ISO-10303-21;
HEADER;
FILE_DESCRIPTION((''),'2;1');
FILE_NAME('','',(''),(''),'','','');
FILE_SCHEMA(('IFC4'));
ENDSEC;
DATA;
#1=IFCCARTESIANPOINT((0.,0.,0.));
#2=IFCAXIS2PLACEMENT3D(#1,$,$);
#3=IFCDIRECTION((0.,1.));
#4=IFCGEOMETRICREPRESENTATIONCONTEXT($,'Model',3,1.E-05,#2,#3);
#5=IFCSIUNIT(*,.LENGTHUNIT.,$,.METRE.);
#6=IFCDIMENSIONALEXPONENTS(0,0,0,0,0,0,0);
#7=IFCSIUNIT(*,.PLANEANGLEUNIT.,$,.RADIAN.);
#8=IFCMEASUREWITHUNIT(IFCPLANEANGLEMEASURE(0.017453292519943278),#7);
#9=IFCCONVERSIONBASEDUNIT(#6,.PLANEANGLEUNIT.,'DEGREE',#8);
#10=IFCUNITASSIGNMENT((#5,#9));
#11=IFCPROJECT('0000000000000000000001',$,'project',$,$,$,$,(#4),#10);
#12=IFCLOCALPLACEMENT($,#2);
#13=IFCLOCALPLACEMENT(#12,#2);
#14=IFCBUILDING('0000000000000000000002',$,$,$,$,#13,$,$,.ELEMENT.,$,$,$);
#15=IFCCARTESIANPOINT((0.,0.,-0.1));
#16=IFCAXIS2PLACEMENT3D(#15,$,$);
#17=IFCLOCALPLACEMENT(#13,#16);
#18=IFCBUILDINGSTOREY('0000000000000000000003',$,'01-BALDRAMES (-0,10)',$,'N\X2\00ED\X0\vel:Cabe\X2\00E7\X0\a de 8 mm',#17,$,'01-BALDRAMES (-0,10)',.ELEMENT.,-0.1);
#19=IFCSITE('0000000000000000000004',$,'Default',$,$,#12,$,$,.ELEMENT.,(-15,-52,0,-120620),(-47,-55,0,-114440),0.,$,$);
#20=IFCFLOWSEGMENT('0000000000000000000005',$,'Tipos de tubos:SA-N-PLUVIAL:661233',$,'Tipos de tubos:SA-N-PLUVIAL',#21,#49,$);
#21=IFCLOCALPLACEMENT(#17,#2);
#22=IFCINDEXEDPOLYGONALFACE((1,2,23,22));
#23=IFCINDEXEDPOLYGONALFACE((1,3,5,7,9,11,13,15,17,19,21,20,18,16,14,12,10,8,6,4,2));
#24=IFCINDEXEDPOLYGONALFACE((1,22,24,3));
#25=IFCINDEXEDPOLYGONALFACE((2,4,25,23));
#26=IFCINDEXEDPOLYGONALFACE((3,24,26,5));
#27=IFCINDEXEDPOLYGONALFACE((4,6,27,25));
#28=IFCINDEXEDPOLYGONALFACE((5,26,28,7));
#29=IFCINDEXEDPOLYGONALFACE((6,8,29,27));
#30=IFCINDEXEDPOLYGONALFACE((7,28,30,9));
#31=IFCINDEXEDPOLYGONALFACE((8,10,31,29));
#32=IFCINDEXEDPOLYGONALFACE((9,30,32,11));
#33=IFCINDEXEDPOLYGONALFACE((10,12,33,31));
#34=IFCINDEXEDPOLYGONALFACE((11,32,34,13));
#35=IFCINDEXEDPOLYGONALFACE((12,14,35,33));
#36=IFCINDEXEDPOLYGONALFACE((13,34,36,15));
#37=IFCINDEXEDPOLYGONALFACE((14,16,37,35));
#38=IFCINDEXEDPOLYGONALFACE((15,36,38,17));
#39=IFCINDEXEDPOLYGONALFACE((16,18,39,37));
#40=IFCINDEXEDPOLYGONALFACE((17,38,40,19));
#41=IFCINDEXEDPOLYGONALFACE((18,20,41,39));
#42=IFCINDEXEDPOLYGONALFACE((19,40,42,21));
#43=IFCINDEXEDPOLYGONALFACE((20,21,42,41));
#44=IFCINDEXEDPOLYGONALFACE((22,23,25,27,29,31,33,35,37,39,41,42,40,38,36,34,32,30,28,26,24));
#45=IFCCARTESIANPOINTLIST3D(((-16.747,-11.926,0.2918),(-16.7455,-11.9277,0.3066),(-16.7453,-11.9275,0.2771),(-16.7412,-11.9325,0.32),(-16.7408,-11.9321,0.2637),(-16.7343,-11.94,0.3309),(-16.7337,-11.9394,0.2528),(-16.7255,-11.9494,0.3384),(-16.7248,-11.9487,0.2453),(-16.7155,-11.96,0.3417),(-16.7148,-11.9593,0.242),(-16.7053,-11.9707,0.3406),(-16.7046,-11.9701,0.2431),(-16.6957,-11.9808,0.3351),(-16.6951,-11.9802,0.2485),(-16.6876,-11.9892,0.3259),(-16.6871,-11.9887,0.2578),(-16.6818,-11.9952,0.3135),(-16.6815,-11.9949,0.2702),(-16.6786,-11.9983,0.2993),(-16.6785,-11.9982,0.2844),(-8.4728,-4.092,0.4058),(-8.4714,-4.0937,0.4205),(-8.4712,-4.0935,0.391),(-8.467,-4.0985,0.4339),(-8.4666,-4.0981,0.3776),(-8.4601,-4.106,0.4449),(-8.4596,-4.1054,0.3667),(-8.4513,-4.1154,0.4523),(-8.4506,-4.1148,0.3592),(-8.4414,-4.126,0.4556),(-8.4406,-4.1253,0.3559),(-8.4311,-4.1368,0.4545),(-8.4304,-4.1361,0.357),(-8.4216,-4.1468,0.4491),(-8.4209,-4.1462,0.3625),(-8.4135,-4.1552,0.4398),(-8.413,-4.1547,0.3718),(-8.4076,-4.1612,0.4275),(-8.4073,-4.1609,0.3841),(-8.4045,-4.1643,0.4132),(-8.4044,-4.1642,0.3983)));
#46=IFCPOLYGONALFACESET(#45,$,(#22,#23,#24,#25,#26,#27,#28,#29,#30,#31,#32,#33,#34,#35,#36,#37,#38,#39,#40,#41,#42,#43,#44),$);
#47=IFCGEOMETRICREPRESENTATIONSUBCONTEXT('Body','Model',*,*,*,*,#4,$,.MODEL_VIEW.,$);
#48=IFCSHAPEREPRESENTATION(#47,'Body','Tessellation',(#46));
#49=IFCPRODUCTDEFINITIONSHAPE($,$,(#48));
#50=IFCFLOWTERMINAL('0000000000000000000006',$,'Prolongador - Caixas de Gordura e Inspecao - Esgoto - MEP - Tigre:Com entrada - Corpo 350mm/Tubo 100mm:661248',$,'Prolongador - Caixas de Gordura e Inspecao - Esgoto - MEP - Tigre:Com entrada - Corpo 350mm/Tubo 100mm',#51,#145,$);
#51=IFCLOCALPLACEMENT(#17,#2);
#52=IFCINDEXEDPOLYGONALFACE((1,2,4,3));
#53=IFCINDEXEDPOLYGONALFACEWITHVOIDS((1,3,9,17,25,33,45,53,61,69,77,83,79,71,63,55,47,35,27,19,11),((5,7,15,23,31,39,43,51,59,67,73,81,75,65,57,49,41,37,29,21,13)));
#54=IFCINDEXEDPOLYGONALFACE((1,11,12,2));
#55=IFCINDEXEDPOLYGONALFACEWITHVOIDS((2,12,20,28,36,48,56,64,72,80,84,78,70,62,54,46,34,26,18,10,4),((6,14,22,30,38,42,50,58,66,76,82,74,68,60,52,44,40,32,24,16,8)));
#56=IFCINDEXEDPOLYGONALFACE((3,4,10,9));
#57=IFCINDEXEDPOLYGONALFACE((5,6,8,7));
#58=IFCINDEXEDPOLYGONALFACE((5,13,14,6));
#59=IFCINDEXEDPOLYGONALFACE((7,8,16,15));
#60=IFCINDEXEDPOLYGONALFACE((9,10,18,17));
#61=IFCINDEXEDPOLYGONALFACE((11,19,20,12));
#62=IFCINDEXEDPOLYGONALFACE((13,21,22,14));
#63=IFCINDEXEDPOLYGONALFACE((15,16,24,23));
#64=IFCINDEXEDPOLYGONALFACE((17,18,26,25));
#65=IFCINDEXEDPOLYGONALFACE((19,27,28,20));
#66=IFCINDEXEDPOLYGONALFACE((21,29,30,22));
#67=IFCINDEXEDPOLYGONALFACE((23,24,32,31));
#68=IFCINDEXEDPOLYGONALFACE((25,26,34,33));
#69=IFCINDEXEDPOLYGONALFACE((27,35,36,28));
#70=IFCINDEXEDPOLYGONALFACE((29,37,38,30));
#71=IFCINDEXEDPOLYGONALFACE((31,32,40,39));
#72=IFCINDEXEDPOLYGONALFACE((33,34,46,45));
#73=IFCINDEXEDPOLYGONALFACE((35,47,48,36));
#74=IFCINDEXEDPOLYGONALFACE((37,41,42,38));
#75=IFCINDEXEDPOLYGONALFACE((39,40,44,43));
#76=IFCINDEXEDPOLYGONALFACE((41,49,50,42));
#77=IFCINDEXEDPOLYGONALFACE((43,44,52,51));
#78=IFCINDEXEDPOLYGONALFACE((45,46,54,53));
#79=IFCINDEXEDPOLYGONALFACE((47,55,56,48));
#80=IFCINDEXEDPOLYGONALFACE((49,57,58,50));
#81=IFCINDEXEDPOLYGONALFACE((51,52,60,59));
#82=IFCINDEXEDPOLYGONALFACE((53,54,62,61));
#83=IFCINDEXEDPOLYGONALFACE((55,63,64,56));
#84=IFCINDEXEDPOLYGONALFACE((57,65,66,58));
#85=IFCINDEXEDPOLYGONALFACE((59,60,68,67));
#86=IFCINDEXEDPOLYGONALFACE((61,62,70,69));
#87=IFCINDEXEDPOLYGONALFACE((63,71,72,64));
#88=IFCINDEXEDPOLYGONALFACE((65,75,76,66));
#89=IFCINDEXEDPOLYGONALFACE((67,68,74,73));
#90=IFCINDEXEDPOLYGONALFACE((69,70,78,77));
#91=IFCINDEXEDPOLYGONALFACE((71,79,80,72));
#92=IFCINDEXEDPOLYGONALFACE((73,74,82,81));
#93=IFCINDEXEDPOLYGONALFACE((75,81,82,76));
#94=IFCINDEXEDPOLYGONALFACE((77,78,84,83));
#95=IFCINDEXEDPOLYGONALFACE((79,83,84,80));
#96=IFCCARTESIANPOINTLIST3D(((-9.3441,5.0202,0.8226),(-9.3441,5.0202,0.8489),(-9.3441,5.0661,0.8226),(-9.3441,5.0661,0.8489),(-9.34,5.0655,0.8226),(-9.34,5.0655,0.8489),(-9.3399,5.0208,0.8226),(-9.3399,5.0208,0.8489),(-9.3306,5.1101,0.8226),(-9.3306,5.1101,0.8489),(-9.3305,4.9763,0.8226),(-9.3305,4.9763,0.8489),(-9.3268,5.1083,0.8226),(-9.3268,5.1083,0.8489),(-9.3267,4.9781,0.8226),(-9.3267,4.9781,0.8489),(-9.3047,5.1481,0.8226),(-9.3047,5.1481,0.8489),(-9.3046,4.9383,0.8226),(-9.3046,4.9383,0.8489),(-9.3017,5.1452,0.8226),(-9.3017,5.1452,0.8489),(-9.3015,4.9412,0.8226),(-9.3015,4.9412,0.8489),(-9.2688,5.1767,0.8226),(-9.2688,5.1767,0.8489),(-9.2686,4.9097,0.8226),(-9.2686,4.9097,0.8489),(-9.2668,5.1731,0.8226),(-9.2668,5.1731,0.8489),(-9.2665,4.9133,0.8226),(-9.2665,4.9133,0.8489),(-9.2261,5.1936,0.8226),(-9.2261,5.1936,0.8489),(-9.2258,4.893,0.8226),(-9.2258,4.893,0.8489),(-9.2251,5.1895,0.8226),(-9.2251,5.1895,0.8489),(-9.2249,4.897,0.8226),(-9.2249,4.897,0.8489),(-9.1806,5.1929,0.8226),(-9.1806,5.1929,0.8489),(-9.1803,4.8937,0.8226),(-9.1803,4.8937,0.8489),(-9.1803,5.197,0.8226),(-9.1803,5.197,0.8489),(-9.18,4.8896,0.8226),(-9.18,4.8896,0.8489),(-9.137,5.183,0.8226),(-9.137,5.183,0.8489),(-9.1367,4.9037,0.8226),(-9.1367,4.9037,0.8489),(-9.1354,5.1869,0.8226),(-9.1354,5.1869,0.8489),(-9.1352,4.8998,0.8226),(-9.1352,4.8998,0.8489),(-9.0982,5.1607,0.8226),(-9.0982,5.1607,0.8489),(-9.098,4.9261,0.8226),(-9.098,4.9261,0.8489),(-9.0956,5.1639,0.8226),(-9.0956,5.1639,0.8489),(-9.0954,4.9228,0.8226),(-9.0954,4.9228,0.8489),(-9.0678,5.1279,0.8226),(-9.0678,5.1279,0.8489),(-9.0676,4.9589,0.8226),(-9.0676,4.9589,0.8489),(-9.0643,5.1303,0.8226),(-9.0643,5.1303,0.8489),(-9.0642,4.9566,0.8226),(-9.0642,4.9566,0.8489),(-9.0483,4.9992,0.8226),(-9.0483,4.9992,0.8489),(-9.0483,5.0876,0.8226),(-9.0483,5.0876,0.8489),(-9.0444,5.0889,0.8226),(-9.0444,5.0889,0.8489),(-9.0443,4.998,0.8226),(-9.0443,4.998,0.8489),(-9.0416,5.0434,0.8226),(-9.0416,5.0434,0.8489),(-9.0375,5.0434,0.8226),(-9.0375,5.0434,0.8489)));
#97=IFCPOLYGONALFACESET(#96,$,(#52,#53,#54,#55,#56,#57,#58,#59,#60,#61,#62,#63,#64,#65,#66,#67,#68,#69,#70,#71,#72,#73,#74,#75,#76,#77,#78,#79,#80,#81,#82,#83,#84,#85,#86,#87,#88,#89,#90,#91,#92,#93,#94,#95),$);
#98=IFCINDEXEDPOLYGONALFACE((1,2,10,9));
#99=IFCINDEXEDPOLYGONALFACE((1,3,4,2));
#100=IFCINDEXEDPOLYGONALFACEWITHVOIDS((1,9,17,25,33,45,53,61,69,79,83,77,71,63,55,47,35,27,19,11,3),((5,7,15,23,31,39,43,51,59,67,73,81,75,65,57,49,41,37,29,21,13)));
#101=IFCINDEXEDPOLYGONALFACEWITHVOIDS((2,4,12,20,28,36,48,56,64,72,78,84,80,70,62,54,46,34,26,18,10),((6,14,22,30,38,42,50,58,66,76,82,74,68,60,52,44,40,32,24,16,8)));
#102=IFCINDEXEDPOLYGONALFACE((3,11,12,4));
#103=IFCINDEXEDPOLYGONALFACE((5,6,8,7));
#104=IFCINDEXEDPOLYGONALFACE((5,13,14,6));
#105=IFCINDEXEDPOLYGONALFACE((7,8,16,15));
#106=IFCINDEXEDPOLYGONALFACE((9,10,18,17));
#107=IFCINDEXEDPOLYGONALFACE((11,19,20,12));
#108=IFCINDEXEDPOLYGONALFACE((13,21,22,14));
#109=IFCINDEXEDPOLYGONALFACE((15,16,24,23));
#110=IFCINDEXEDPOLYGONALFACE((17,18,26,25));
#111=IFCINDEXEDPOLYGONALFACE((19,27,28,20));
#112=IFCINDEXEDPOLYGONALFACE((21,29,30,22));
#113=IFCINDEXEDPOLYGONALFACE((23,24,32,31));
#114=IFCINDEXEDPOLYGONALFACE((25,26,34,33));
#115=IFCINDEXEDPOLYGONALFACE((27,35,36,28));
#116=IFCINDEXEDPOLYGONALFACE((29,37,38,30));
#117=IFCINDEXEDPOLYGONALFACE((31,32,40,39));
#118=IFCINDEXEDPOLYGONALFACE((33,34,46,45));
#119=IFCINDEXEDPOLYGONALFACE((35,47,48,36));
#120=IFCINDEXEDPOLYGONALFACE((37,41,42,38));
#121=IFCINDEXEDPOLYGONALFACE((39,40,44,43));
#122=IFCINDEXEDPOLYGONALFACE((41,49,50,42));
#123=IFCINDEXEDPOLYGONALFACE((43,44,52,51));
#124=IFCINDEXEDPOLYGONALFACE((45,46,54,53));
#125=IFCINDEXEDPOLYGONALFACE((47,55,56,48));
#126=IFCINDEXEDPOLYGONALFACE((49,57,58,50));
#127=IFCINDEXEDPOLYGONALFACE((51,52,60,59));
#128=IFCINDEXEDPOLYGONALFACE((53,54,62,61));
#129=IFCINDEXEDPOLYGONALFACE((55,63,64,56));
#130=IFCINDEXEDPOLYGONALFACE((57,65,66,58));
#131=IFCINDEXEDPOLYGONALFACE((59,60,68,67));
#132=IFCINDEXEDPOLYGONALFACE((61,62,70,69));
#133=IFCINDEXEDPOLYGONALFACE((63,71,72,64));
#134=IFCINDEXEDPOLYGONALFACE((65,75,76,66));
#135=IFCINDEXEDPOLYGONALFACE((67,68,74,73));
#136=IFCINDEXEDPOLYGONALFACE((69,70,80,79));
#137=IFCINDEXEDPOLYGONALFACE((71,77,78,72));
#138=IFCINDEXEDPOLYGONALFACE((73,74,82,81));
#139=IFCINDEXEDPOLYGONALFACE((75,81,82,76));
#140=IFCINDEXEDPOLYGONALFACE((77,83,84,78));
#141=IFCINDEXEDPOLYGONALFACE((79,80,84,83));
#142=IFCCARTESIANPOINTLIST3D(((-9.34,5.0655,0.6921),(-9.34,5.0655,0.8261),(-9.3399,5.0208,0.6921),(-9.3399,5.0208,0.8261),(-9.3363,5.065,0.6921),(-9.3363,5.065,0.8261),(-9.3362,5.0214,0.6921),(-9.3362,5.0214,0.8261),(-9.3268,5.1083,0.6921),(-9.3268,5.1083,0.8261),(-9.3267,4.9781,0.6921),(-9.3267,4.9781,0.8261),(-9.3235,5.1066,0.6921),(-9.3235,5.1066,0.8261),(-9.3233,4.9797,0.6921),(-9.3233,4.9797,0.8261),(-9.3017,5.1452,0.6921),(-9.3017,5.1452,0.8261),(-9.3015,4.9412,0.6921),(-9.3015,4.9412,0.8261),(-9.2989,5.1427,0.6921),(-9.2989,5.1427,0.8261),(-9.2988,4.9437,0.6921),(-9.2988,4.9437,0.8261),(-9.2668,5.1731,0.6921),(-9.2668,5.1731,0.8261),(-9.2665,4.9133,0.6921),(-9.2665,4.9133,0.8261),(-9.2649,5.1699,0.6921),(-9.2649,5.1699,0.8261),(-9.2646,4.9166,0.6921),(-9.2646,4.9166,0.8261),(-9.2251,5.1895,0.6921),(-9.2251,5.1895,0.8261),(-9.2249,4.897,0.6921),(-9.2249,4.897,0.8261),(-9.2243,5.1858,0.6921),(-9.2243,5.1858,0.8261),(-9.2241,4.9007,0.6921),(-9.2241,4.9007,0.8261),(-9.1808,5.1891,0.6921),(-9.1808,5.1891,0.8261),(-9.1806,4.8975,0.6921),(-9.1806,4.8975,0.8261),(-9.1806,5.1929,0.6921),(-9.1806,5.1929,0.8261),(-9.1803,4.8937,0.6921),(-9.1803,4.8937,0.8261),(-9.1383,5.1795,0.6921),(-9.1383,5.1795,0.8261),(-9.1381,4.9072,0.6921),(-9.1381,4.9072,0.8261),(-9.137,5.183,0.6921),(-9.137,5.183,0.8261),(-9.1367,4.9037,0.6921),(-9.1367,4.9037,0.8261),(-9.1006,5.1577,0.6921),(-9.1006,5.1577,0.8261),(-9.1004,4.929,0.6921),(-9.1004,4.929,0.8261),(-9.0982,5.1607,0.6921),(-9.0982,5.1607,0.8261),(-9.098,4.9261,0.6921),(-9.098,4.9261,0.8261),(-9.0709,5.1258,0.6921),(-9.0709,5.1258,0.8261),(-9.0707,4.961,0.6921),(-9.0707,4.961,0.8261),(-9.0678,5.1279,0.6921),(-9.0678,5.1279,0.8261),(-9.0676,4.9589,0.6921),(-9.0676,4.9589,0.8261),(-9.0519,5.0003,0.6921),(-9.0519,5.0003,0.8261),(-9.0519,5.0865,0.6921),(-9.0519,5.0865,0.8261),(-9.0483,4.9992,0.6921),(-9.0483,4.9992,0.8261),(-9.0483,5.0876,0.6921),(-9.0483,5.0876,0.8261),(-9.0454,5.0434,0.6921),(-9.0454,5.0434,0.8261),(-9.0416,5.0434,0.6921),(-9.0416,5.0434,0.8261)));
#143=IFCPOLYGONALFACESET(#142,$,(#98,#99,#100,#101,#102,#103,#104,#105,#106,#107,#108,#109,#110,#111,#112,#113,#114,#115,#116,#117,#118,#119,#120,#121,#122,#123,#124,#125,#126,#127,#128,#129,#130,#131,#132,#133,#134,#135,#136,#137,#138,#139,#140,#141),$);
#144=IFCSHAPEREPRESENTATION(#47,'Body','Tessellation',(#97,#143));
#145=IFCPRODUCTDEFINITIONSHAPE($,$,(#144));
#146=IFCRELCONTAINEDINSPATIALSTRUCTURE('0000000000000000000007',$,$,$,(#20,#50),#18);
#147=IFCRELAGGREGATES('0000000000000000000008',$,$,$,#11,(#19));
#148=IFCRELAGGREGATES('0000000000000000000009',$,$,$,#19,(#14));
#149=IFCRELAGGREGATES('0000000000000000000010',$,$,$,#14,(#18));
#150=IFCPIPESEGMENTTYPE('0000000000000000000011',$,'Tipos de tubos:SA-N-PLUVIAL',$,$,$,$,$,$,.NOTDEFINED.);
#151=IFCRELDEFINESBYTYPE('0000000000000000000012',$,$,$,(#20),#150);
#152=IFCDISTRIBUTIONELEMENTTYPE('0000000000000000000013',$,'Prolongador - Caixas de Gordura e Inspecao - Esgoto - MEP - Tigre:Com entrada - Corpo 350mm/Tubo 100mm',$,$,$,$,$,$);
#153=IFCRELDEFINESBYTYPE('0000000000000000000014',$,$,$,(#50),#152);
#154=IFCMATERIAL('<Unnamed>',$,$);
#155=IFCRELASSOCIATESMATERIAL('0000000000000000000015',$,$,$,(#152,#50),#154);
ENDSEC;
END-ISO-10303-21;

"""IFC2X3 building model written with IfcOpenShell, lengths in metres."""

from ifc_helpers import new_model, entity, si_unit, converted_unit, direction, frame, frame_2d, origin, place, context, subcontext, project, spatial, circle, hollow_circle, extrude, source, transform, mapped, material, type_object, type_shapes, element, save


model = new_model("IFC2X3")

# Units and contexts
model_context = context("Model", 3, precision=1e-05, world=origin(), true_north=direction((0.0, 1.0)))
body_context = subcontext(model_context, "Body", "Model", "MODEL_VIEW")
ifc_project = project(units=[si_unit("LENGTHUNIT", "METRE"), converted_unit("PLANEANGLEUNIT", "DEGREE", entity("IfcPlaneAngleMeasure", 0.017453292519943278), si_unit("PLANEANGLEUNIT", "RADIAN"), dimensions=[0, 0, 0, 0, 0, 0, 0])], contexts=[model_context])

# Site, building, storey
site_placement = place(None, origin())
site = spatial("IfcSite", under=ifc_project, at=site_placement, Name="Default", CompositionType="ELEMENT", RefLatitude=(-15, -52, 0, -120620), RefLongitude=(-47, -55, 0, -114440), RefElevation=0.0)
building_placement = place(site_placement, origin())
building = spatial("IfcBuilding", under=site, at=building_placement, CompositionType="ELEMENT")
storey_placement = place(building_placement, frame((0.0, 0.0, -0.1)))
storey = spatial("IfcBuildingStorey", under=building, at=storey_placement, Name="01-BALDRAMES (-0,10)", ObjectType="Nível:Cabeça de 8 mm", LongName="01-BALDRAMES (-0,10)", CompositionType="ELEMENT", Elevation=-0.1)

# Flow segment
pipe_segment_type_1 = type_object("IfcPipeSegmentType", Name="Tipos de tubos:SA-N-PLUVIAL", PredefinedType="NOTDEFINED")
flow_segment_1_placement = place(storey_placement, origin())
element("IfcFlowSegment", 1, at=flow_segment_1_placement, inside=storey, type_object=pipe_segment_type_1, Name="Tipos de tubos:SA-N-PLUVIAL:661233", ObjectType="Tipos de tubos:SA-N-PLUVIAL", context=body_context, shape_type="SweptSolid", body=[
    extrude(circle(Radius=0.05, at=frame_2d((0.0, 0.0), x_axis=(1.0, 0.0))), frame((-16.7126, -11.9623, 0.2918), z_axis=(0.726122, 0.687493, 0.009999), x_axis=(-0.687528, 0.726158, 0.0)), (0.0, 0.0, 1.0), 11.395),
])

# Flow terminal
ifc_material = material(Name="<Unnamed>")
distribution_element_type_1 = type_object("IfcDistributionElementType", Name="Prolongador - Caixas de Gordura e Inspecao - Esgoto - MEP - Tigre:Com entrada - Corpo 350mm/Tubo 100mm", material=ifc_material)
shared_shape_1 = source(origin(), body_context, "Body", "SweptSolid", [
    extrude(hollow_circle(Radius=0.1542, WallThickness=0.0042, at=frame_2d((0.0, 0.0), x_axis=(1.0, 0.0))), frame((0.0, 0.0, -0.0574), z_axis=(0.0, 0.0, 1.0), x_axis=(0.0, -1.0, 0.0)), (0.0, 0.0, 1.0), 0.0263),
    extrude(hollow_circle(Radius=0.15, WallThickness=0.0038, at=frame_2d((0.0, 0.0), x_axis=(1.0, 0.0))), frame((0.0, 0.0, -0.1879), z_axis=(0.0, 0.0, 1.0), x_axis=(0.0, -1.0, 0.0)), (0.0, 0.0, 1.0), 0.134),
])
type_shapes(distribution_element_type_1, [shared_shape_1])
flow_terminal_1_placement = place(storey_placement, frame((-9.1916, 5.0433, 0.88), z_axis=(0.0, 0.0, 1.0), x_axis=(-0.000878, 1.0, 0.0)))
element("IfcFlowTerminal", 2, at=flow_terminal_1_placement, inside=storey, type_object=distribution_element_type_1, material=ifc_material, Name="Prolongador - Caixas de Gordura e Inspecao - Esgoto - MEP - Tigre:Com entrada - Corpo 350mm/Tubo 100mm:661248", ObjectType="Prolongador - Caixas de Gordura e Inspecao - Esgoto - MEP - Tigre:Com entrada - Corpo 350mm/Tubo 100mm", context=body_context, shape_type="MappedRepresentation", body=[
    mapped(shared_shape_1, transform((0.0, 0.0, 0.0), scale=1.0)),
])

save(model, "model.ifc")
